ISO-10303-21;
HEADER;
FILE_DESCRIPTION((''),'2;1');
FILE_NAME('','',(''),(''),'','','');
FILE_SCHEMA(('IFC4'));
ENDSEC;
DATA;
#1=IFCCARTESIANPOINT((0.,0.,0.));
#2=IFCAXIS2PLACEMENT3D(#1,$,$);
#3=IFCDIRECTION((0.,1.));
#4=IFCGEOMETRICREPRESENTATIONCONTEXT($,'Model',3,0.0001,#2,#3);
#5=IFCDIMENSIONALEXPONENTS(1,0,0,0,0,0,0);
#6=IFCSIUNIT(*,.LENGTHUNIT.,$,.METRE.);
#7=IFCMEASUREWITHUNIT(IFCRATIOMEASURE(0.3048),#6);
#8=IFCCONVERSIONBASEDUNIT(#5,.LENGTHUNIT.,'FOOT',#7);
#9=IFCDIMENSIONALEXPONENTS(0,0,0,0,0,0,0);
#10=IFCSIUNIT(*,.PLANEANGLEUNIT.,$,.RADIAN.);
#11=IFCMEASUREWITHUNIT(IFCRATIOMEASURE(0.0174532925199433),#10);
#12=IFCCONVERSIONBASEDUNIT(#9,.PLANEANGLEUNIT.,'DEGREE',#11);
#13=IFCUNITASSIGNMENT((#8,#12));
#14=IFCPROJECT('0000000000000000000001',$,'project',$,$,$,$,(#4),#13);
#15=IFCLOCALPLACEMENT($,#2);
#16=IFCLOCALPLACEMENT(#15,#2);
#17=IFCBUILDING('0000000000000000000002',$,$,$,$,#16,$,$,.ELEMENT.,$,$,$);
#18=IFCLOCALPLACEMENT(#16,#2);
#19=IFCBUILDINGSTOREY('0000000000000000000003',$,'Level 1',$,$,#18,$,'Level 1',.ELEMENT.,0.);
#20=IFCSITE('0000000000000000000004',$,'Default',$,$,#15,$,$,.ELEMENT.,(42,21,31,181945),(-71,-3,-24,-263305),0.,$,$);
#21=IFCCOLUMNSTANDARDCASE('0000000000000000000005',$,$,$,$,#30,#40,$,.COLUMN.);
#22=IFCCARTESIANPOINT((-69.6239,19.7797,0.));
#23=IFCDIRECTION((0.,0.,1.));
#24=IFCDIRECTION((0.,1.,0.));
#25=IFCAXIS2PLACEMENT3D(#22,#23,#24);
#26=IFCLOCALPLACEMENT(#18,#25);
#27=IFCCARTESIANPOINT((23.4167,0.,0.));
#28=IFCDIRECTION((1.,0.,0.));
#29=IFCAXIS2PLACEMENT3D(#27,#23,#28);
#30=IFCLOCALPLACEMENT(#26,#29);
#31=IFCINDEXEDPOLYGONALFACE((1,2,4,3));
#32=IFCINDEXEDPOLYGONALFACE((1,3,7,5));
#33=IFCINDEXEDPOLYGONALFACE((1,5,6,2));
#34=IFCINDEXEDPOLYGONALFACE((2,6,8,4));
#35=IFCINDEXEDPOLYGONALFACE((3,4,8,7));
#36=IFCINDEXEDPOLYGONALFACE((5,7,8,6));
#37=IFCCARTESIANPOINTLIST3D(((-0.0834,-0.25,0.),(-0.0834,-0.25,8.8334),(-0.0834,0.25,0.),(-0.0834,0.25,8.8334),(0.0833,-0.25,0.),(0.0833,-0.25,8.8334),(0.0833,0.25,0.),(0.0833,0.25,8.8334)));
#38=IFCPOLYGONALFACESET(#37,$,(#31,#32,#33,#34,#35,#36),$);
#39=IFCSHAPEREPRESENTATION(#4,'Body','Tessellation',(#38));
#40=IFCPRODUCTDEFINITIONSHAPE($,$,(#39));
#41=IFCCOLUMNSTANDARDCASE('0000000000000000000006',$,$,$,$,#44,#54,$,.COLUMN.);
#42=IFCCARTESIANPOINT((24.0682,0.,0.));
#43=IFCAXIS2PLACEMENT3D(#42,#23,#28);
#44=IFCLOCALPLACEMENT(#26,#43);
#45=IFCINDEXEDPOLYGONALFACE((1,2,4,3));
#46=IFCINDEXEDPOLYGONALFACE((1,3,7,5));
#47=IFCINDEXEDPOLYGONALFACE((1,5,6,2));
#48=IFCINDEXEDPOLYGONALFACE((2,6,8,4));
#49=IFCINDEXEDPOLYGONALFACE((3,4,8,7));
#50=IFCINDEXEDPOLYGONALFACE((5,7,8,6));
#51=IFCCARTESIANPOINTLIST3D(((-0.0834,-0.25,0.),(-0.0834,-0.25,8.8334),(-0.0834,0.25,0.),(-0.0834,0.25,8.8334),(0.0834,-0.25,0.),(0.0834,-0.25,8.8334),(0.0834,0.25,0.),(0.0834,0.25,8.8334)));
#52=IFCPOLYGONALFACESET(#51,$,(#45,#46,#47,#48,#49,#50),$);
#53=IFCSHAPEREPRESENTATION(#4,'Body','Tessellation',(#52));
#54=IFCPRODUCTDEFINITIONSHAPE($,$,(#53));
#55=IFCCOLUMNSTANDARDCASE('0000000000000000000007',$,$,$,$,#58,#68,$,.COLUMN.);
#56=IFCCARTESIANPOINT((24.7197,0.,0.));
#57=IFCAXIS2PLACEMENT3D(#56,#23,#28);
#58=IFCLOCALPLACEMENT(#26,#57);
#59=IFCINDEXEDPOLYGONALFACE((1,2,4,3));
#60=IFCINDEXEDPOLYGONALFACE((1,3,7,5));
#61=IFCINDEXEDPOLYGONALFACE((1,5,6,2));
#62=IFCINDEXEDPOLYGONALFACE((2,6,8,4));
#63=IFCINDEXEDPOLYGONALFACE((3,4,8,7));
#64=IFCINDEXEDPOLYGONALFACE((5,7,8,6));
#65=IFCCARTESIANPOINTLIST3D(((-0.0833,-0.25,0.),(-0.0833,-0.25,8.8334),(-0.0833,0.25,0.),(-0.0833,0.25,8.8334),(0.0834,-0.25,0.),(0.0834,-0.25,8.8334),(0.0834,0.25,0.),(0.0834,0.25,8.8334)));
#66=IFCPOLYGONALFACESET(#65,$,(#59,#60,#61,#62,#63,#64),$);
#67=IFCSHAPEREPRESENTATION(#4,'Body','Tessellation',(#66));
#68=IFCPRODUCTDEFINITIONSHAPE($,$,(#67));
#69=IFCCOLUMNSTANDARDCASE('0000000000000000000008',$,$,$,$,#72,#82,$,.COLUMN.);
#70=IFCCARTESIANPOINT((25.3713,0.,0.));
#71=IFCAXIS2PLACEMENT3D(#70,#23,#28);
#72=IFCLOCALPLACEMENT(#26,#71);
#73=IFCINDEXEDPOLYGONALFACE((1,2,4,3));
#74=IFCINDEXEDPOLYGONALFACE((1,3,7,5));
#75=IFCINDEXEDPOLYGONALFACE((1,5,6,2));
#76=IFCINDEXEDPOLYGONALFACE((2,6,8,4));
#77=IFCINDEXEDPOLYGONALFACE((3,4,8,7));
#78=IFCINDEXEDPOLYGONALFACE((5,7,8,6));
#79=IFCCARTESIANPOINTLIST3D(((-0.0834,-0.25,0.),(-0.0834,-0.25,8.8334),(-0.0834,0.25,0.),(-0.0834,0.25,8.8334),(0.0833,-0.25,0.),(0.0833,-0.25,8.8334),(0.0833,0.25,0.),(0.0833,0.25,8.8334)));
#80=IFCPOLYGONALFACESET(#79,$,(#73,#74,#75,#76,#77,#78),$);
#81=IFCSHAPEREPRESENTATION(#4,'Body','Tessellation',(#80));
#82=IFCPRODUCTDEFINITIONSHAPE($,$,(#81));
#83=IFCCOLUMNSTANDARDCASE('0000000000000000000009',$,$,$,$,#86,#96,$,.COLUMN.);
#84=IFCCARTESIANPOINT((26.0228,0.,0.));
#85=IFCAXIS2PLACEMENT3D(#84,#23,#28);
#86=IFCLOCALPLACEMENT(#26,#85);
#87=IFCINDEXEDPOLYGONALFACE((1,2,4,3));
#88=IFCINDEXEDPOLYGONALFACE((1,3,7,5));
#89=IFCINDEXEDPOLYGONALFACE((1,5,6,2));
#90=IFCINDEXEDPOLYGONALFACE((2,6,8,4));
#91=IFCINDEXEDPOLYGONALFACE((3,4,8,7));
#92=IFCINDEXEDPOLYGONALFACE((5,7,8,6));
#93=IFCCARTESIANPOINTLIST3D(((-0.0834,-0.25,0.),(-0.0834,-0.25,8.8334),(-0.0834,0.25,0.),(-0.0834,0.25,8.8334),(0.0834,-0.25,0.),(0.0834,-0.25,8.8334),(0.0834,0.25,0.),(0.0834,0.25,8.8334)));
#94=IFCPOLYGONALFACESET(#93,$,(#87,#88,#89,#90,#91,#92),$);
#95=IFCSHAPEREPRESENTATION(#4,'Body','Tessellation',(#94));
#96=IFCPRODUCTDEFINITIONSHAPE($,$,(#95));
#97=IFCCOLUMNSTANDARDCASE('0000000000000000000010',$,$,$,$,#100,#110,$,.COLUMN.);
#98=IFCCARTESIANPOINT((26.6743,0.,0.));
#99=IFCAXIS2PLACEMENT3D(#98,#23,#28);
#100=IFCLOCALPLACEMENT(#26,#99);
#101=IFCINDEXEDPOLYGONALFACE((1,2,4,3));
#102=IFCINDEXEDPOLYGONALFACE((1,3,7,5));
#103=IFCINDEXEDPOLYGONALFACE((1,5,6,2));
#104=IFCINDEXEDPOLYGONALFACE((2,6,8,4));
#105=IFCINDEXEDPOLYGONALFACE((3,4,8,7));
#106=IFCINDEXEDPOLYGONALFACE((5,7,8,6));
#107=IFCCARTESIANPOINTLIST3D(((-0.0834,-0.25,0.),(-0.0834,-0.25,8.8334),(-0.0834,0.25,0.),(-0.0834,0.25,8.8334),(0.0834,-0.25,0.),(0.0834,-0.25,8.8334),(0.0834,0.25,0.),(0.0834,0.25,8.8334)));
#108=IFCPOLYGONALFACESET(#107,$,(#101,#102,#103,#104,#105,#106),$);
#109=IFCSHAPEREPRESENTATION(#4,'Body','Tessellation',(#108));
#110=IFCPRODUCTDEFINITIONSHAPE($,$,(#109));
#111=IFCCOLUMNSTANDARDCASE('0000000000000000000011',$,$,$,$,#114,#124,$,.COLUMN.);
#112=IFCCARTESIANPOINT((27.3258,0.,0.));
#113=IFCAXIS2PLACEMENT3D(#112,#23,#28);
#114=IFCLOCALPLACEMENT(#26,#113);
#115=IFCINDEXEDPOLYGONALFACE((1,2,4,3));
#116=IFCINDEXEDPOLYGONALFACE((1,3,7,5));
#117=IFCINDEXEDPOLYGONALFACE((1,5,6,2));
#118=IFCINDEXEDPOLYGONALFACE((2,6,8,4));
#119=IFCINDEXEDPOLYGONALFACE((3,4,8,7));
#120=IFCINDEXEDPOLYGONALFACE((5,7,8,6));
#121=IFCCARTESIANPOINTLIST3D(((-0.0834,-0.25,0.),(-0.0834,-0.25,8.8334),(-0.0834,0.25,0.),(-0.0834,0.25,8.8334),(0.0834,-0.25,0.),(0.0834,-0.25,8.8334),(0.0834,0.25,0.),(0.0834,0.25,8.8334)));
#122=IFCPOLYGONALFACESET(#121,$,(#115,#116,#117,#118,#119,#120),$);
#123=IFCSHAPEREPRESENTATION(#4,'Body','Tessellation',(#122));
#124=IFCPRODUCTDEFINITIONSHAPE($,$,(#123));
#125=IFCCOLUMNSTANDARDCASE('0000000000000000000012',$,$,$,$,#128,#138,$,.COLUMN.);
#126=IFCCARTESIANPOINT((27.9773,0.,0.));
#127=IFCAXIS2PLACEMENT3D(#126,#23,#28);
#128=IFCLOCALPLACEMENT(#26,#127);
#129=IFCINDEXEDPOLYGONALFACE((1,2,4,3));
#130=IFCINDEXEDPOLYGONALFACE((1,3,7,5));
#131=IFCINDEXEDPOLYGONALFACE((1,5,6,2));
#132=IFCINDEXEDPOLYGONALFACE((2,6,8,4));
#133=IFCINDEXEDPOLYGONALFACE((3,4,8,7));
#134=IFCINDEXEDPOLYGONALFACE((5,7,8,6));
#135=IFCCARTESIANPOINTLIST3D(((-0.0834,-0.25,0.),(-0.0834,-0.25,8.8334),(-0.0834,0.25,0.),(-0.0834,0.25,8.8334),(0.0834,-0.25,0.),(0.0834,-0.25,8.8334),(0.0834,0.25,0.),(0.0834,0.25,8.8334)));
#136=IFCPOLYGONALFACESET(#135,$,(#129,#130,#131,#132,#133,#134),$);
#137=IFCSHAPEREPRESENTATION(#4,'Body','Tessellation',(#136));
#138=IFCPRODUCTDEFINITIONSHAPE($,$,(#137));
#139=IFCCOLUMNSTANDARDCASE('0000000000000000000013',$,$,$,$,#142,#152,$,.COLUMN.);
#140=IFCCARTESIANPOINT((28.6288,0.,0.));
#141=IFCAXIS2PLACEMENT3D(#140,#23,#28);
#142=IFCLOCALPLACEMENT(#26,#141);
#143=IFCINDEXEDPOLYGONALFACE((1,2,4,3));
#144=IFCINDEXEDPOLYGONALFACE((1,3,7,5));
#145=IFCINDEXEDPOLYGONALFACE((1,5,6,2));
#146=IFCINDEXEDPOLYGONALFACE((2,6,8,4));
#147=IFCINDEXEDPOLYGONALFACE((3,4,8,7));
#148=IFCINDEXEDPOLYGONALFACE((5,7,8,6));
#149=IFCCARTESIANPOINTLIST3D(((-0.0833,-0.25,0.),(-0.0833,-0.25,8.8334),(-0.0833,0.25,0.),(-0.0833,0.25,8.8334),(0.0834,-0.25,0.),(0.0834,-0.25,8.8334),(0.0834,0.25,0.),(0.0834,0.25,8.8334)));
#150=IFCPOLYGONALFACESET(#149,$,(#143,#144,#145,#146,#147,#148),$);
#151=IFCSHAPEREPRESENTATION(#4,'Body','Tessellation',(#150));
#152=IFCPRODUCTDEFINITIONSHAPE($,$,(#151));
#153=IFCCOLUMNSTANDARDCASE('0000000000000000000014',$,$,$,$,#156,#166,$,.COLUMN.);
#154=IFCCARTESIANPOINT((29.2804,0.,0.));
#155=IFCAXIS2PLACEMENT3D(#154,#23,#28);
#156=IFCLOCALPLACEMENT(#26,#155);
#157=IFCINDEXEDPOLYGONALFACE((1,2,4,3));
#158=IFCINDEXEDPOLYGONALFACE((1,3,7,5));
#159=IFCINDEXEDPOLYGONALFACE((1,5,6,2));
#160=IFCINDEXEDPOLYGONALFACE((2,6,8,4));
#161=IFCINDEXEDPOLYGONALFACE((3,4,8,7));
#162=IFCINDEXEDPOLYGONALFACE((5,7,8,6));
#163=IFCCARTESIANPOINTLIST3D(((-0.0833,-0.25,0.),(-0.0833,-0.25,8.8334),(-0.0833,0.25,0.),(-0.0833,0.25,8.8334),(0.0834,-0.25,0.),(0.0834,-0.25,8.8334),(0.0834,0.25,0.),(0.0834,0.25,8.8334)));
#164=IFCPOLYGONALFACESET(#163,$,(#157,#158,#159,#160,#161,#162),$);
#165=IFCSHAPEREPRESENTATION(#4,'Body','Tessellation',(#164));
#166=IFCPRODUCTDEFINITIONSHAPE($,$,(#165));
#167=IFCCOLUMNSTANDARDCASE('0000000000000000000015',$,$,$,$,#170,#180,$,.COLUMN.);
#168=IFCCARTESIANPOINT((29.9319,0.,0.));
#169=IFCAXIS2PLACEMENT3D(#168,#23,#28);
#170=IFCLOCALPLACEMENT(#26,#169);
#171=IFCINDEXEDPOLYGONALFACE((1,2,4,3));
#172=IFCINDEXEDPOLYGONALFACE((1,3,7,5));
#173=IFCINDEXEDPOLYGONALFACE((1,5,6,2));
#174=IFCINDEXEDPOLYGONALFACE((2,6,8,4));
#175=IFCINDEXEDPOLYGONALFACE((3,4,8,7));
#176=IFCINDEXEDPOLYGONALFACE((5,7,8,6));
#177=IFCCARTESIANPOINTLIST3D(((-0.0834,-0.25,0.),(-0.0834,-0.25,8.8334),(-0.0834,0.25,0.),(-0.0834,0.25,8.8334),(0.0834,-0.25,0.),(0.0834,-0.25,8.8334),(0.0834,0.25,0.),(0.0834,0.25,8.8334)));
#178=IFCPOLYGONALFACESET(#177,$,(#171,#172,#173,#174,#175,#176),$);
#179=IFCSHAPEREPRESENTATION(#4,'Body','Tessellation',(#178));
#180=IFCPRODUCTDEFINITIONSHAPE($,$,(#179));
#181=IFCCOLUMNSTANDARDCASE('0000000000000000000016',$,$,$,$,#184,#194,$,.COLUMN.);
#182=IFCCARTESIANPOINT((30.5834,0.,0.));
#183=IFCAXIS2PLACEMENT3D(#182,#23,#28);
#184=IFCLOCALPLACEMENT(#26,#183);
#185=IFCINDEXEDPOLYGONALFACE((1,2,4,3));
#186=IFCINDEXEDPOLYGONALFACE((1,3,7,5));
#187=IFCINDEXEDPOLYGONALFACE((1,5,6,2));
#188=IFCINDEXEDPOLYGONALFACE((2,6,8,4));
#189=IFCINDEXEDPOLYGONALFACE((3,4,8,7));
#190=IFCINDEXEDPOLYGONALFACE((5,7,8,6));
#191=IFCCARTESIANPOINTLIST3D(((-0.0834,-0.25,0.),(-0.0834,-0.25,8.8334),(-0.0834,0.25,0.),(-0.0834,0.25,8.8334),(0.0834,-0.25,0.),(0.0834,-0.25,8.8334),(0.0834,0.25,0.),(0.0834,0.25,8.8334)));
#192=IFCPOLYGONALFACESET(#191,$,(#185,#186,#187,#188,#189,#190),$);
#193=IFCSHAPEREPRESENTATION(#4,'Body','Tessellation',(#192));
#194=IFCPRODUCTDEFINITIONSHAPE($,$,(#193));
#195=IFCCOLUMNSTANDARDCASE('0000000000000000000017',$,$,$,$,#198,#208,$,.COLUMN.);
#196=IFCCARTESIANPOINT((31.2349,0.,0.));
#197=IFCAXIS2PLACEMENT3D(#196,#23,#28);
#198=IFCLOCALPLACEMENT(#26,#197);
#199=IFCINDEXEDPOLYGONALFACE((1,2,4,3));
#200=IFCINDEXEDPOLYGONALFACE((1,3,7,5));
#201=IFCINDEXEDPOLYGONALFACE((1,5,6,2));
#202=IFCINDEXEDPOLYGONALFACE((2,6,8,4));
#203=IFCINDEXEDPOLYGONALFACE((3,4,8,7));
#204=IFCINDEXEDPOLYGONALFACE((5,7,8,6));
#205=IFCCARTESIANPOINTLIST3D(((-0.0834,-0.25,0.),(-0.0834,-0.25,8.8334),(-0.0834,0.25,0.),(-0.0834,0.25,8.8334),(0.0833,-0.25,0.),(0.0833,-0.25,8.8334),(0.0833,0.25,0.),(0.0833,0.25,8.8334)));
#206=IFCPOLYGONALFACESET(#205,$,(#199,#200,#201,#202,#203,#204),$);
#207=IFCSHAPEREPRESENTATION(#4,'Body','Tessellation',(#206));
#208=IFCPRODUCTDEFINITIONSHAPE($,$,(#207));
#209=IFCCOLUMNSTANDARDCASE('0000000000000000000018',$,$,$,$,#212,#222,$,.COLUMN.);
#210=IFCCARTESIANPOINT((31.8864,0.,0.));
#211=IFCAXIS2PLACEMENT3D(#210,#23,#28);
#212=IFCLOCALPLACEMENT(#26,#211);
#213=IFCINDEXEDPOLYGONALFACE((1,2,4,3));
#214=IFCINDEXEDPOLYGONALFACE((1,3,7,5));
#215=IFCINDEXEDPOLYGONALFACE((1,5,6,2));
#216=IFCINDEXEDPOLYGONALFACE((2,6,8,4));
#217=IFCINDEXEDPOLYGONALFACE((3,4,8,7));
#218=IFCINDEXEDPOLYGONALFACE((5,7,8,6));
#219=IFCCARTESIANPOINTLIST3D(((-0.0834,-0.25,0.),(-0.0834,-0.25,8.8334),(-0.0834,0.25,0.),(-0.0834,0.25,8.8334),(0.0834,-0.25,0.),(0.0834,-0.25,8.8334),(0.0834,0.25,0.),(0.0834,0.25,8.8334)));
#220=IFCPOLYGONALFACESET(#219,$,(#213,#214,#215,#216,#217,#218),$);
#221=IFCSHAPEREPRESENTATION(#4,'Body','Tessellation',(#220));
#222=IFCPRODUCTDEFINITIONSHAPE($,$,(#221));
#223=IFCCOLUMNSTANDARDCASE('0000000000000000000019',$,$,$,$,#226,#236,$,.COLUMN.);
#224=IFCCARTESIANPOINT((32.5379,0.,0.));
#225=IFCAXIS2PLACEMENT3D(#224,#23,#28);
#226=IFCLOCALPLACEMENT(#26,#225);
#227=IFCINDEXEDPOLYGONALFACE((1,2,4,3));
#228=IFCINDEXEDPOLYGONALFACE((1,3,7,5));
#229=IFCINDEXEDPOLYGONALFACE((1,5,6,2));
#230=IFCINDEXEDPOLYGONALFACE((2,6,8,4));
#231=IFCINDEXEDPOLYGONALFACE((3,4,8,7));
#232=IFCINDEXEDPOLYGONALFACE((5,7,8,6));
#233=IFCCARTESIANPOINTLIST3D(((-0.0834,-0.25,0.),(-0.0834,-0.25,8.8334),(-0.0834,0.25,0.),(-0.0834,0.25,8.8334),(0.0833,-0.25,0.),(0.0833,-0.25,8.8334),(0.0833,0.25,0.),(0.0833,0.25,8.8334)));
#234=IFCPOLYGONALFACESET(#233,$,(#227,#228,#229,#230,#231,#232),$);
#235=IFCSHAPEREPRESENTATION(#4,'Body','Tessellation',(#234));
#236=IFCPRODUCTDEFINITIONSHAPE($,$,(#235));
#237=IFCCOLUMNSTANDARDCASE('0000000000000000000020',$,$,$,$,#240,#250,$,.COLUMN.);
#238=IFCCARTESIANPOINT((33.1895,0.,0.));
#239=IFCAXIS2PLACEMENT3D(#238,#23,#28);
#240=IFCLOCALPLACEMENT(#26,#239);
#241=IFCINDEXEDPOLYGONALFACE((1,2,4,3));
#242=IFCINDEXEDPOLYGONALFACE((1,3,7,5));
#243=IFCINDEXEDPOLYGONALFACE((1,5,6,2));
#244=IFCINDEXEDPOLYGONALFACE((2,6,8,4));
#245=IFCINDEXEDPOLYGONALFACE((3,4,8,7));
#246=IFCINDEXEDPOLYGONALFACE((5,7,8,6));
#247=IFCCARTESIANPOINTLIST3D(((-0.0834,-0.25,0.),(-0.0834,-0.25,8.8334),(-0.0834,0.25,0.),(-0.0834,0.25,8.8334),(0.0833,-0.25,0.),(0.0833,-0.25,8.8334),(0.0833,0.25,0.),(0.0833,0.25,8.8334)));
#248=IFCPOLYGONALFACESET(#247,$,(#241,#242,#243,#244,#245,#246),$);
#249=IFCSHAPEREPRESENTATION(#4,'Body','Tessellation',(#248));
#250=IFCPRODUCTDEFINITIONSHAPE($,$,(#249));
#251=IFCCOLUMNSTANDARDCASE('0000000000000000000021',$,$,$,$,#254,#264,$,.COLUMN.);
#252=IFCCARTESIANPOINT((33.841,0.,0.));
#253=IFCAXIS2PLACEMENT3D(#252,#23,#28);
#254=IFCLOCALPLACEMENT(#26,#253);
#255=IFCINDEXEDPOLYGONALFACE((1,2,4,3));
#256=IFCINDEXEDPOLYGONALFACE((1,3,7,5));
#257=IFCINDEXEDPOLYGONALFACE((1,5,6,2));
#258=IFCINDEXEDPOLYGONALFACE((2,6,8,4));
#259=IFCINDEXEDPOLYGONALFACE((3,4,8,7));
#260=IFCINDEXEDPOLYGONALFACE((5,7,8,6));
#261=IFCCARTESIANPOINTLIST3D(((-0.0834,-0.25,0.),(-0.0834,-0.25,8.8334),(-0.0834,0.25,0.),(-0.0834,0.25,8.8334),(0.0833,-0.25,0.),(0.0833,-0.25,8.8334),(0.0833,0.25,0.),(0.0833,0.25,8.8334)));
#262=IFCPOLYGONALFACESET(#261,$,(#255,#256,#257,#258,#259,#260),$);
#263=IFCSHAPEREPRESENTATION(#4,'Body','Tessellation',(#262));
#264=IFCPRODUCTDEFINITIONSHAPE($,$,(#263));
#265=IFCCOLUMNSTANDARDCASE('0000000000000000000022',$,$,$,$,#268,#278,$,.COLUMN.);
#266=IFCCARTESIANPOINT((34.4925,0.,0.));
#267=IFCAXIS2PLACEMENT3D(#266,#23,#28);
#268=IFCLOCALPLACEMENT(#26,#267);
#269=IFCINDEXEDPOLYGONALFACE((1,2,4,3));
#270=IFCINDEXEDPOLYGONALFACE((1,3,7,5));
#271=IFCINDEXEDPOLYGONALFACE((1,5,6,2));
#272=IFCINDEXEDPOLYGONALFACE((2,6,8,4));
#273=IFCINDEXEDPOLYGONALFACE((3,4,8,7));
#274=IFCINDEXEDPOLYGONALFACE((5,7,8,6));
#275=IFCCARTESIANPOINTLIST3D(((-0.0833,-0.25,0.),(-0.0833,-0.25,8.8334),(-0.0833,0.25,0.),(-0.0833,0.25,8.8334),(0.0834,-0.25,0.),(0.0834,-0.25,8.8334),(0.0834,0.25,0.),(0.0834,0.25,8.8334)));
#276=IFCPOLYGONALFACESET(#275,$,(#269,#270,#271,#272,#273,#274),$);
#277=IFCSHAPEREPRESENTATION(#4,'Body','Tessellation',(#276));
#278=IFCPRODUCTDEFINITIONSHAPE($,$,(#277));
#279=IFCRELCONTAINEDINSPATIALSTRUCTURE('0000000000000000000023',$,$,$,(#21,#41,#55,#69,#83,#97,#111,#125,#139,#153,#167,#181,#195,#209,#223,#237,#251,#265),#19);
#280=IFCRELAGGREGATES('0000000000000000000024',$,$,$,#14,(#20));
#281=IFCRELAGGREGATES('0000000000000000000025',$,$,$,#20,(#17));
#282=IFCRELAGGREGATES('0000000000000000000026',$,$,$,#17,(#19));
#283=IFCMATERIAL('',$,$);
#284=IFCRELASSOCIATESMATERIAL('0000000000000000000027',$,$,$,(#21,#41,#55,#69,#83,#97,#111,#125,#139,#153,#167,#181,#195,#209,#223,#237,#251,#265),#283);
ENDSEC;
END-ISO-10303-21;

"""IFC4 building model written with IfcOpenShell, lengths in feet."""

from ifc_helpers import new_model, entity, si_unit, converted_unit, direction, frame, origin, place, context, project, spatial, rectangle, extrude, material, element, save


model = new_model("IFC4")

# Units and contexts
model_context = context("Model", 3, precision=0.0001, world=origin(), true_north=direction((0.0, 1.0)))
ifc_project = project(units=[converted_unit("LENGTHUNIT", "FOOT", entity("IfcRatioMeasure", 0.3048), si_unit("LENGTHUNIT", "METRE"), dimensions=[1, 0, 0, 0, 0, 0, 0]), converted_unit("PLANEANGLEUNIT", "DEGREE", entity("IfcRatioMeasure", 0.0174532925199433), si_unit("PLANEANGLEUNIT", "RADIAN"), dimensions=[0, 0, 0, 0, 0, 0, 0])], contexts=[model_context])

# Site, building, storey
site_placement = place(None, origin())
site = spatial("IfcSite", under=ifc_project, at=site_placement, Name="Default", CompositionType="ELEMENT", RefLatitude=(42, 21, 31, 181945), RefLongitude=(-71, -3, -24, -263305), RefElevation=0.0)
building_placement = place(site_placement, origin())
building = spatial("IfcBuilding", under=site, at=building_placement, CompositionType="ELEMENT")
storey_placement = place(building_placement, origin())
storey = spatial("IfcBuildingStorey", under=building, at=storey_placement, Name="Level 1", LongName="Level 1", CompositionType="ELEMENT", Elevation=0.0)

# Columns
ifc_material_1 = material(Name="")
placement_1 = place(storey_placement, frame((-69.6239, 19.7797, 0.0), z_axis=(0.0, 0.0, 1.0), x_axis=(0.0, 1.0, 0.0)))
for number, where, z_axis, x_axis in (
    (1, (23.4167, 0.0, 0.0), (0.0, 0.0, 1.0), (1.0, 0.0, 0.0)),
    (2, (24.0682, 0.0, 0.0), (0.0, 0.0, 1.0), (1.0, 0.0, 0.0)),
    (3, (24.7197, 0.0, 0.0), (0.0, 0.0, 1.0), (1.0, 0.0, 0.0)),
    (4, (25.3713, 0.0, 0.0), (0.0, 0.0, 1.0), (1.0, 0.0, 0.0)),
    (5, (26.0228, 0.0, 0.0), (0.0, 0.0, 1.0), (1.0, 0.0, 0.0)),
    (6, (26.6743, 0.0, 0.0), (0.0, 0.0, 1.0), (1.0, 0.0, 0.0)),
    (7, (27.3258, 0.0, 0.0), (0.0, 0.0, 1.0), (1.0, 0.0, 0.0)),
    (8, (27.9773, 0.0, 0.0), (0.0, 0.0, 1.0), (1.0, 0.0, 0.0)),
    (9, (28.6288, 0.0, 0.0), (0.0, 0.0, 1.0), (1.0, 0.0, 0.0)),
    (10, (29.2804, 0.0, 0.0), (0.0, 0.0, 1.0), (1.0, 0.0, 0.0)),
    (11, (29.9319, 0.0, 0.0), (0.0, 0.0, 1.0), (1.0, 0.0, 0.0)),
    (12, (30.5834, 0.0, 0.0), (0.0, 0.0, 1.0), (1.0, 0.0, 0.0)),
    (13, (31.2349, 0.0, 0.0), (0.0, 0.0, 1.0), (1.0, 0.0, 0.0)),
    (14, (31.8864, 0.0, 0.0), (0.0, 0.0, 1.0), (1.0, 0.0, 0.0)),
    (15, (32.5379, 0.0, 0.0), (0.0, 0.0, 1.0), (1.0, 0.0, 0.0)),
    (16, (33.1895, 0.0, 0.0), (0.0, 0.0, 1.0), (1.0, 0.0, 0.0)),
    (17, (33.841, 0.0, 0.0), (0.0, 0.0, 1.0), (1.0, 0.0, 0.0)),
    (18, (34.4925, 0.0, 0.0), (0.0, 0.0, 1.0), (1.0, 0.0, 0.0)),
):
    element("IfcColumnStandardCase", number, at=place(placement_1, frame(where, z_axis=z_axis, x_axis=x_axis)), inside=storey, material=ifc_material_1, PredefinedType="COLUMN", context=model_context, shape_type="SweptSolid", body=[
        extrude(rectangle(XDim=0.1667, YDim=0.5), origin(), (0.0, 0.0, 1.0), 8.8334),
    ])

save(model, "model.ifc")
